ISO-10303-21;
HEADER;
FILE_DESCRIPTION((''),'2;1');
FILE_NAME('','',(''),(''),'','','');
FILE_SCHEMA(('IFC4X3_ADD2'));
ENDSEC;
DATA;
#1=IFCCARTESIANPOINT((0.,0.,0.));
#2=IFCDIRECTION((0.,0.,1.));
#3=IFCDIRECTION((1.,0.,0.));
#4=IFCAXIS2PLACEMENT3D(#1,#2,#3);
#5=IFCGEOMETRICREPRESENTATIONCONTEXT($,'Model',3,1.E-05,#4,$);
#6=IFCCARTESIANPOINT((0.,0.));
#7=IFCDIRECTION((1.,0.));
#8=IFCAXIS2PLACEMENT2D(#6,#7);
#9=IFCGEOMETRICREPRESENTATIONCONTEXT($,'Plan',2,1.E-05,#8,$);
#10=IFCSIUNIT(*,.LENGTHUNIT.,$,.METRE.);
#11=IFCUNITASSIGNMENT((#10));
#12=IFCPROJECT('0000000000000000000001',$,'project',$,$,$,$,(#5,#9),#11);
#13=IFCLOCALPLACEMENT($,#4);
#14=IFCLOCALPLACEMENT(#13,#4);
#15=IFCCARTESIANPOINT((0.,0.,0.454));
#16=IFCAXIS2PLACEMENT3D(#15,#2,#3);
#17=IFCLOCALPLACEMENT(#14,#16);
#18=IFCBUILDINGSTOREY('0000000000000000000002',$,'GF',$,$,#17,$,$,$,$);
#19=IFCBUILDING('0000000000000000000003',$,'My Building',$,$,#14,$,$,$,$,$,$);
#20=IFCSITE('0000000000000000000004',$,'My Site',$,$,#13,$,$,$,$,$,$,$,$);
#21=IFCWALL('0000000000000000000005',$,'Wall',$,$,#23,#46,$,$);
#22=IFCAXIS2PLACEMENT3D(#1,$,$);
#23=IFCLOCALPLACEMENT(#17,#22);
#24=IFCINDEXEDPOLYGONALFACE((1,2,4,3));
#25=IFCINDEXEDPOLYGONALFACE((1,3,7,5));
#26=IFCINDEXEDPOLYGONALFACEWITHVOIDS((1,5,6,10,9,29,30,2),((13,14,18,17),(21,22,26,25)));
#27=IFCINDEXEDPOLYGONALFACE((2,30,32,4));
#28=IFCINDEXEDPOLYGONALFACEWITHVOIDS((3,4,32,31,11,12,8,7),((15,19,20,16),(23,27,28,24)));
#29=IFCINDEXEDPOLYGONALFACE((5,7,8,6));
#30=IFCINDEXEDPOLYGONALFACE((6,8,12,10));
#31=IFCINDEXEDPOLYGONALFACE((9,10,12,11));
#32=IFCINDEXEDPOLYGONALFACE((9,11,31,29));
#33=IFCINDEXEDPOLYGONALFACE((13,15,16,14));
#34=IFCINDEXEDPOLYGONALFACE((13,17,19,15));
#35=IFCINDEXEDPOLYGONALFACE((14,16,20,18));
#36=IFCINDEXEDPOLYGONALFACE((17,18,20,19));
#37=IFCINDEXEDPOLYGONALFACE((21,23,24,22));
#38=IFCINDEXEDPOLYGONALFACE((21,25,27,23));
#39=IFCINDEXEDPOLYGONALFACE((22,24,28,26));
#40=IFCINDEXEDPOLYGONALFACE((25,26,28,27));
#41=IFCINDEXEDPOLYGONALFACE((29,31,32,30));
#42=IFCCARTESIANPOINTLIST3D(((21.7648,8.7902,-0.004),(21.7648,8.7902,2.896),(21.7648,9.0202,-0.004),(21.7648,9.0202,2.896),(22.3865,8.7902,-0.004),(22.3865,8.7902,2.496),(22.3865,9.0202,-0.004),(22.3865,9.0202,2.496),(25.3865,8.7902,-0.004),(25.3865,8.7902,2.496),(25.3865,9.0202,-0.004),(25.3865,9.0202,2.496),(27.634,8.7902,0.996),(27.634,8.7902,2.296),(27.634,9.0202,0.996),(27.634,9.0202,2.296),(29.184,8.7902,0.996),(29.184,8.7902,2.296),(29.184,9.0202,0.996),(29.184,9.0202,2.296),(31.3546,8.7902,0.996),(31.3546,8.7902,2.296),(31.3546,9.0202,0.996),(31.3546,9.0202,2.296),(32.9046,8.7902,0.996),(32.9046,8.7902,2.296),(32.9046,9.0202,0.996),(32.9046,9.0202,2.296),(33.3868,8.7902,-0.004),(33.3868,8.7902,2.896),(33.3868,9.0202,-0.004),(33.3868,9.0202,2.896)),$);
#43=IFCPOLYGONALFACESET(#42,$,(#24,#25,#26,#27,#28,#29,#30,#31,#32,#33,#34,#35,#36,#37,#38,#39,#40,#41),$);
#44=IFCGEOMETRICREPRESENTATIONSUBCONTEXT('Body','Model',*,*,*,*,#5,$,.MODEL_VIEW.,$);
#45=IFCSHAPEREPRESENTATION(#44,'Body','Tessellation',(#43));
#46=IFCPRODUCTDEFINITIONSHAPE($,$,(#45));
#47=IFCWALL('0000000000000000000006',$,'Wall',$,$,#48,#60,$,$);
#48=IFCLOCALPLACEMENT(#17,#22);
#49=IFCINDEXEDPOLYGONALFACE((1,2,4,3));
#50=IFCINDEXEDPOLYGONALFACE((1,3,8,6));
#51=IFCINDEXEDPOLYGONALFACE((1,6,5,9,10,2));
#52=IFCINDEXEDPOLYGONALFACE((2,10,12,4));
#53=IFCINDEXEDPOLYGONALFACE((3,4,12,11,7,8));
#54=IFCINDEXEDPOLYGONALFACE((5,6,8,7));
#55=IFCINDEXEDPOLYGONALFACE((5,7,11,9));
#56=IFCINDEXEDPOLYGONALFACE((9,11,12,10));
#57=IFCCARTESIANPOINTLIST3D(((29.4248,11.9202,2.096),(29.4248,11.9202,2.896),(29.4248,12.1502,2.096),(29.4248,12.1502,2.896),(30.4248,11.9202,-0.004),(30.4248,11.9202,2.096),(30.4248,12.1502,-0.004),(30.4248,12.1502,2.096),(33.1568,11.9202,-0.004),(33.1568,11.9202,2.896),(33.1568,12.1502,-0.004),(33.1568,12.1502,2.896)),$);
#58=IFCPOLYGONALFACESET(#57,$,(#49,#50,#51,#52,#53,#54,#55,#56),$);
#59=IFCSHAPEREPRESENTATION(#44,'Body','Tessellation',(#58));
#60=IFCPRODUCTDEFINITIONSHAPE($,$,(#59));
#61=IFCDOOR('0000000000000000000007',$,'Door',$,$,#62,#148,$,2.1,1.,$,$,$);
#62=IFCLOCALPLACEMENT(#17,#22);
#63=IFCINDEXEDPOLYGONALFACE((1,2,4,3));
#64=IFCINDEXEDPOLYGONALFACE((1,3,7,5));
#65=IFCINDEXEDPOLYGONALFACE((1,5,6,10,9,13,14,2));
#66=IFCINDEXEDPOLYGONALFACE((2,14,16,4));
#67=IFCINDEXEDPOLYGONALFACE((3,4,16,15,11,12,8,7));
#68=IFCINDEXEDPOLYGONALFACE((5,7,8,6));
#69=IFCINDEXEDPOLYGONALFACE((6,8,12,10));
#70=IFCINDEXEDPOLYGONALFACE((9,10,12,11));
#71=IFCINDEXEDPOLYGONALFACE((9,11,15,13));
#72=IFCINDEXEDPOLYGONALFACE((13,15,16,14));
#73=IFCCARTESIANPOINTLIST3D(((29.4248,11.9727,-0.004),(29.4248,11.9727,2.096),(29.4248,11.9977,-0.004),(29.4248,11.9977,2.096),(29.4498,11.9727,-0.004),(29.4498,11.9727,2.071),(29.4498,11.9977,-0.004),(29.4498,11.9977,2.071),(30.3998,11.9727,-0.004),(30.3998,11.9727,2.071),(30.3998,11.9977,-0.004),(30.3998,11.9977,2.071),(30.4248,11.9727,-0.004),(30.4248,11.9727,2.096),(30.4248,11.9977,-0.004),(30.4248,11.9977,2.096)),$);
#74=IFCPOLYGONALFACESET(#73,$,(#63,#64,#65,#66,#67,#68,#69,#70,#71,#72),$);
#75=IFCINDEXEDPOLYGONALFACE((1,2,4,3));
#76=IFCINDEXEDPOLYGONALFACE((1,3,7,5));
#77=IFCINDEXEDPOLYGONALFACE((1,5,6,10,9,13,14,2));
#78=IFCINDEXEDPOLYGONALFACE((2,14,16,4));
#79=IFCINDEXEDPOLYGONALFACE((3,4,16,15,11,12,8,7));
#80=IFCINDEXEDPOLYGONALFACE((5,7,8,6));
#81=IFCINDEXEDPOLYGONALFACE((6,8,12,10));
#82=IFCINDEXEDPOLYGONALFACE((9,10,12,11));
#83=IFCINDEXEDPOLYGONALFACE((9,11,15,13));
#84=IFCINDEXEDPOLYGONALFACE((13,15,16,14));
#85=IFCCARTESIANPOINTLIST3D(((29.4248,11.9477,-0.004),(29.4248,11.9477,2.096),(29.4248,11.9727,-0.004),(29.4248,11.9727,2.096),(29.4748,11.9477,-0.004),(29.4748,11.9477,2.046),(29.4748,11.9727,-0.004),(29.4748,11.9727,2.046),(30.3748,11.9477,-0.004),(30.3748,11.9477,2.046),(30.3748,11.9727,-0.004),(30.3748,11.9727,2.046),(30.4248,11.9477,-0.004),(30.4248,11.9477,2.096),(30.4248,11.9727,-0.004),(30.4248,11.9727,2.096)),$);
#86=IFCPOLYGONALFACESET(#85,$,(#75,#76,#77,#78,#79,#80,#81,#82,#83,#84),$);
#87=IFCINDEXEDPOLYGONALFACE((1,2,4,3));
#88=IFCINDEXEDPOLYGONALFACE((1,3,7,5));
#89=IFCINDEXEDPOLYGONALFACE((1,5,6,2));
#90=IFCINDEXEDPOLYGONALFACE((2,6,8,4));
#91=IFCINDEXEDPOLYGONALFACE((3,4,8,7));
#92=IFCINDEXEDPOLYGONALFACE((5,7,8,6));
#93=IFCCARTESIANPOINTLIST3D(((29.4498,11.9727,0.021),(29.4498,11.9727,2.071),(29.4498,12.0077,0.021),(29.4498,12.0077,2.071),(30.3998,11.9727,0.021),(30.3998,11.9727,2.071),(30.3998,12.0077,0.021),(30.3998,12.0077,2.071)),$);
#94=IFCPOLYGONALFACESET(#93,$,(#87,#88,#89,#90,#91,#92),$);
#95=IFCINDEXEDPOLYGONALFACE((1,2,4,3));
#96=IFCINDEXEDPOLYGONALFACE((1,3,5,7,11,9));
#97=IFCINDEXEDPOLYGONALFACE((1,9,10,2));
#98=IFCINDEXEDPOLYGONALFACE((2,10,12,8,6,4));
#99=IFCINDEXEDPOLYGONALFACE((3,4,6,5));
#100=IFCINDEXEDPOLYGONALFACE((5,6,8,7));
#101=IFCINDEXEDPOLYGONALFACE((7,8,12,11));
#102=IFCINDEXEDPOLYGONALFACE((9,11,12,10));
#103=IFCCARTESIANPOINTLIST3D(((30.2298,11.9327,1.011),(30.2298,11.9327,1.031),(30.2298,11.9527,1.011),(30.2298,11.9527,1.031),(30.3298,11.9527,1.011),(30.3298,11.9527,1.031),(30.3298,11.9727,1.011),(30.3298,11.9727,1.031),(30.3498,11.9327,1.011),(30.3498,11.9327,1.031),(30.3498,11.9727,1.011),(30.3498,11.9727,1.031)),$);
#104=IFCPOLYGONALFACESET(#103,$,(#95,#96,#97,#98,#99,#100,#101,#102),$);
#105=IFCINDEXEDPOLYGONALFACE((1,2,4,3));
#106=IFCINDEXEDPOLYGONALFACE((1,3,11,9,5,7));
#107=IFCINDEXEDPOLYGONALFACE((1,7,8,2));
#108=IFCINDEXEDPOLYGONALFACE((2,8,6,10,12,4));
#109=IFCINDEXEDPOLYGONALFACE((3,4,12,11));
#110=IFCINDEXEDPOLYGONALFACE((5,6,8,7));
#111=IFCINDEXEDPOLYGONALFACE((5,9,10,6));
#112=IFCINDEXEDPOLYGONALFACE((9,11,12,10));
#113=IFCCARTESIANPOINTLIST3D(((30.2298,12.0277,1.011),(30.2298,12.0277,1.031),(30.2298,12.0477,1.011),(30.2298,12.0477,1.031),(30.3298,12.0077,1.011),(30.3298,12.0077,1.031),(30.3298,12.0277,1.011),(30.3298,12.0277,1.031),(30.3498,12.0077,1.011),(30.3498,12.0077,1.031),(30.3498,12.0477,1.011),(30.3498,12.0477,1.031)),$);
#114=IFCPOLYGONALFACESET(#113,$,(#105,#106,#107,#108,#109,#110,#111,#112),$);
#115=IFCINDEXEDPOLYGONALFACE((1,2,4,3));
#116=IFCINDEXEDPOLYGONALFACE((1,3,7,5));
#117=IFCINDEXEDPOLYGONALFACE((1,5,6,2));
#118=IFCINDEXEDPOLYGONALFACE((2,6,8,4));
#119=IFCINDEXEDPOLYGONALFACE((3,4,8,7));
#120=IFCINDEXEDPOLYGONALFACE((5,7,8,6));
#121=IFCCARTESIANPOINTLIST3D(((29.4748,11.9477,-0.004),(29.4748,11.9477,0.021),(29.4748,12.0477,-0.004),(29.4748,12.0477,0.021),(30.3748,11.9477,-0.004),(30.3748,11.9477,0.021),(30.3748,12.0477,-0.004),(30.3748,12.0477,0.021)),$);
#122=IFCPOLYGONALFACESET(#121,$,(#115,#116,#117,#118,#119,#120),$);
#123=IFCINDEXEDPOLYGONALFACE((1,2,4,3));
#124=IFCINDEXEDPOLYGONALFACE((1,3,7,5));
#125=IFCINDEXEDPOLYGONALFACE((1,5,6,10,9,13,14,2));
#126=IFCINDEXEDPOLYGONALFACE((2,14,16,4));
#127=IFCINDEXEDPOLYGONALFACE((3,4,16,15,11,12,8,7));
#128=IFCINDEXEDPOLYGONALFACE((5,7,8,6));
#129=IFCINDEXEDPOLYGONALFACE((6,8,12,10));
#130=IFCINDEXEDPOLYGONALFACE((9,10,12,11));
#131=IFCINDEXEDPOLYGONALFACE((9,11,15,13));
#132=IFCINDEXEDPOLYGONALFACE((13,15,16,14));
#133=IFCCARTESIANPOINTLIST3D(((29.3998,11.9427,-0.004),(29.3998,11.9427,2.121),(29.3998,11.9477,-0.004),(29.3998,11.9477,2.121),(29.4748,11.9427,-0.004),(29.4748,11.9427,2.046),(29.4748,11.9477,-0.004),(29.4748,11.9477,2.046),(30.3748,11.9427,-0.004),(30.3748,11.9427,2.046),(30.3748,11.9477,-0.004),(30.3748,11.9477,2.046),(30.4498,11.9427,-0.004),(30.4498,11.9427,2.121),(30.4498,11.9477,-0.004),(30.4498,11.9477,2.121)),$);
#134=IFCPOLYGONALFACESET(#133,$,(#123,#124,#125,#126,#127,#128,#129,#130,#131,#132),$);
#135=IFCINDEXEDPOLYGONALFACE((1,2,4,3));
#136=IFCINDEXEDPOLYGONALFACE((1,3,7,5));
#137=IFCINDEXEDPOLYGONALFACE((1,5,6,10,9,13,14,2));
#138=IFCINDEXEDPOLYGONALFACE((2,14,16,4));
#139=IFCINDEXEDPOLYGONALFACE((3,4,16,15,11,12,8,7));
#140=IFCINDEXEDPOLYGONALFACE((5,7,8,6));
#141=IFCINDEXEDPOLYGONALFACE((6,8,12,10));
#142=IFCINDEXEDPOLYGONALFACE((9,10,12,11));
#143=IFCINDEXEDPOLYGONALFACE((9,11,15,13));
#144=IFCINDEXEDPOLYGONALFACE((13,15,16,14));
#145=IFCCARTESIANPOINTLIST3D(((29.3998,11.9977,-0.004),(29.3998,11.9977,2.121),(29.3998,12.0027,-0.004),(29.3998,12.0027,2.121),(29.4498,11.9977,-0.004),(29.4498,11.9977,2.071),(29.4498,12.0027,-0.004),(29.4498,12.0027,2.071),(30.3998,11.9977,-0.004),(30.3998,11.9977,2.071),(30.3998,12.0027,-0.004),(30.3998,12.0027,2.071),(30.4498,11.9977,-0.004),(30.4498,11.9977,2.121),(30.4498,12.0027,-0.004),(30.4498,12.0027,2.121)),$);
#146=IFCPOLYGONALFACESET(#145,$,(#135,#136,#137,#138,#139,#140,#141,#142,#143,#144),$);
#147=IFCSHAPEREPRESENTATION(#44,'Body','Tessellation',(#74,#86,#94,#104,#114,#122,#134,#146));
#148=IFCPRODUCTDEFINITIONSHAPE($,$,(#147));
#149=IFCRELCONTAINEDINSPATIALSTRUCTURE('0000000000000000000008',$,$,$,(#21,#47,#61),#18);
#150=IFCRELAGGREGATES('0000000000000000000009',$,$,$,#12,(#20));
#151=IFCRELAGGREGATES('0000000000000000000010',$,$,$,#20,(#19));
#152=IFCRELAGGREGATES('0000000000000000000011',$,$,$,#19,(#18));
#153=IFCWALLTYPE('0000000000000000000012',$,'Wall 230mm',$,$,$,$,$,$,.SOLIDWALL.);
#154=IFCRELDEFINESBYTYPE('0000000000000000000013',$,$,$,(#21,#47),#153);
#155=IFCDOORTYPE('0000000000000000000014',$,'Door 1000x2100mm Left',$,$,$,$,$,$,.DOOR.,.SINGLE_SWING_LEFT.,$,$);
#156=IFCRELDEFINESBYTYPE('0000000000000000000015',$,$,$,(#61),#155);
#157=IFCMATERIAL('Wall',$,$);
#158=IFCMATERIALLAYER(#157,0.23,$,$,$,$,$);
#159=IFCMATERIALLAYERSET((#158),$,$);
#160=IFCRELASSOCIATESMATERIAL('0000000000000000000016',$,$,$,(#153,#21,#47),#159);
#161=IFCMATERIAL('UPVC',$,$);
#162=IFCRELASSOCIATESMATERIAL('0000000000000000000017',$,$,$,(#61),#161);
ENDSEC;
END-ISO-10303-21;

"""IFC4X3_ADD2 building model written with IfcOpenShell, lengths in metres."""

from ifc_helpers import new_model, entity, si_unit, frame, origin_with_axes, origin_2d_with_axis, place, context, subcontext, project, spatial, line, indexed_curve, outline, extrude, shape, source, transform, mapped, material, layer, layer_set, layer_usage, type_object, type_shapes, element, fill, save


model = new_model("IFC4X3_ADD2")

# Units and contexts
model_context = context("Model", 3, precision=1e-05, world=origin_with_axes())
plan_context = context("Plan", 2, precision=1e-05, world=origin_2d_with_axis())
body_context_1 = subcontext(model_context, "Body", "Model", "MODEL_VIEW")
body_context_2 = subcontext(plan_context, "Body", "Plan", "PLAN_VIEW")
ifc_project = project(units=[si_unit("LENGTHUNIT", "METRE")], contexts=[model_context, plan_context])

# Site, building, storey
site_placement = place(None, origin_with_axes())
site = spatial("IfcSite", under=ifc_project, at=site_placement, Name="My Site")
building_placement = place(site_placement, origin_with_axes())
building = spatial("IfcBuilding", under=site, at=building_placement, Name="My Building")
storey_placement = place(building_placement, frame((0.0, 0.0, 0.454), z_axis=(0.0, 0.0, 1.0), x_axis=(1.0, 0.0, 0.0)))
storey = spatial("IfcBuildingStorey", under=building, at=storey_placement, Name="GF")

# Shared definitions
ifc_material_1 = material(Name="Wall")

# Wall, openings
ifc_layer_1 = layer(ifc_material_1, 0.23)
ifc_layer_set_1 = layer_set([ifc_layer_1])
ifc_layer_usage_1 = layer_usage(ifc_layer_set_1, "AXIS2", "POSITIVE", 0.0)
wall_type_1 = type_object("IfcWallType", Name="Wall 230mm", PredefinedType="SOLIDWALL", material=ifc_layer_set_1)
wall_1_placement = place(storey_placement, frame((33.3868, 9.0202, -0.004), z_axis=(0.0, 0.0, 1.0), x_axis=(-1.0, 0.0, 0.0)))
wall_1 = element("IfcWall", 1, at=wall_1_placement, inside=storey, type_object=wall_type_1, material=ifc_layer_usage_1, Name="Wall", context=body_context_1, shape_type="SweptSolid", body=[
    extrude(outline(indexed_curve([(0.0, 0.0), (0.0, 0.23), (11.622, 0.23), (11.622, 0.0), (0.0, 0.0)], self_intersect=False)), origin_with_axes(), (0.0, 0.0, 1.0), 2.9),
])
shared_shape_1 = source(origin_with_axes(), body_context_1, "Body", "SweptSolid", [
    extrude(outline(indexed_curve([(0.0, 0.0), (3.0, 0.0), (3.0, 2.5), (0.0, 2.5)], segments=[line(1, 2, 3, 4, 1)])), frame((0.0, -0.6, 0.0), z_axis=(0.0, -1.0, 0.0), x_axis=(1.0, 0.0, 0.0)), (0.0, 0.0, -1.0), 1.2),
])
opening_1_placement = place(wall_1_placement, frame((8.0003, 0.0, 0.0), z_axis=(0.0, 0.0, 1.0), x_axis=(1.0, 0.0, 0.0)))
element("IfcOpeningElement", 2, at=opening_1_placement, cuts=wall_1, PredefinedType="OPENING", context=body_context_1, shape_type="MappedRepresentation", body=[
    mapped(shared_shape_1, transform((0.0, 0.0, 0.0), x_axis=(1.0, 0.0, 0.0), y_axis=(0.0, 1.0, 0.0), z_axis=(0.0, 0.0, 1.0), scale=1.0)),
])
shared_shape_2 = source(origin_with_axes(), body_context_1, "Body", "SweptSolid", [
    extrude(outline(indexed_curve([(0.0, 0.0), (1.55, 0.0), (1.55, 1.3), (0.0, 1.3)], segments=[line(1, 2, 3, 4, 1)])), frame((-0.775, -0.6, 0.0), z_axis=(0.0, -1.0, 0.0), x_axis=(1.0, 0.0, 0.0)), (0.0, 0.0, -1.0), 1.2),
])
opening_2_placement = place(wall_1_placement, frame((1.2571, 0.0, 1.0), z_axis=(0.0, 0.0, 1.0), x_axis=(1.0, 0.0, 0.0)))
element("IfcOpeningElement", 3, at=opening_2_placement, cuts=wall_1, PredefinedType="OPENING", context=body_context_1, shape_type="MappedRepresentation", body=[
    mapped(shared_shape_2, transform((0.0, 0.0, 0.0), x_axis=(1.0, 0.0, 0.0), y_axis=(0.0, 1.0, 0.0), z_axis=(0.0, 0.0, 1.0), scale=1.0)),
])
opening_3_placement = place(wall_1_placement, frame((4.9778, 0.0, 1.0), z_axis=(0.0, 0.0, 1.0), x_axis=(1.0, 0.0, 0.0)))
element("IfcOpeningElement", 4, at=opening_3_placement, cuts=wall_1, PredefinedType="OPENING", context=body_context_1, shape_type="MappedRepresentation", body=[
    mapped(shared_shape_2, transform((0.0, 0.0, 0.0), x_axis=(1.0, 0.0, 0.0), y_axis=(0.0, 1.0, 0.0), z_axis=(0.0, 0.0, 1.0), scale=1.0)),
])

# Wall, opening, door
ifc_layer_usage_2 = layer_usage(ifc_layer_set_1, "AXIS2", "POSITIVE", 0.0)
wall_2_placement = place(storey_placement, frame((33.1568, 12.1502, -0.004), z_axis=(0.0, 0.0, 1.0), x_axis=(-1.0, 0.0, 0.0)))
wall_2 = element("IfcWall", 5, at=wall_2_placement, inside=storey, type_object=wall_type_1, material=ifc_layer_usage_2, Name="Wall", context=body_context_1, shape_type="SweptSolid", body=[
    extrude(outline(indexed_curve([(0.0, 0.0), (0.0, 0.23), (3.732, 0.23), (3.732, 0.0), (0.0, 0.0)], self_intersect=False)), origin_with_axes(), (0.0, 0.0, 1.0), 2.9),
])
shared_shape_3 = source(origin_with_axes(), body_context_1, "Body", "SweptSolid", [
    extrude(outline(indexed_curve([(0.0, 0.0), (1.0, 0.0), (1.0, 2.1), (0.0, 2.1)], segments=[line(1, 2, 3, 4, 1)])), frame((0.0, -0.6, 0.0), z_axis=(0.0, -1.0, 0.0), x_axis=(1.0, 0.0, 0.0)), (0.0, 0.0, -1.0), 1.2),
])
opening_4_placement = place(wall_2_placement, frame((3.732, 0.2024, 0.0), z_axis=(0.0, 0.0, 1.0), x_axis=(-1.0, 0.0, 0.0)))
opening_4 = element("IfcOpeningElement", 6, at=opening_4_placement, cuts=wall_2, PredefinedType="OPENING", context=body_context_1, shape_type="MappedRepresentation", body=[
    mapped(shared_shape_3, transform((0.0, 0.0, 0.0), x_axis=(1.0, 0.0, 0.0), y_axis=(0.0, 1.0, 0.0), z_axis=(0.0, 0.0, 1.0), scale=1.0)),
])
ifc_material_2 = material(Name="UPVC")
door_type = type_object("IfcDoorType", Name="Door 1000x2100mm Left", OperationType="SINGLE_SWING_LEFT", PredefinedType="DOOR")
shared_shape_4 = source(origin_with_axes(), body_context_1, "Body", "SweptSolid", [
    extrude(outline(indexed_curve([(0.0, 0.0), (0.0, 2.1), (1.0, 2.1), (1.0, 0.0), (0.975, 0.0), (0.975, 2.075), (0.025, 2.075), (0.025, 0.0)], segments=[line(1, 2, 3, 4, 5, 6, 7, 8, 1)])), frame((0.0, 0.025, 0.0), z_axis=(0.0, -1.0, 0.0), x_axis=(1.0, 0.0, 0.0)), (0.0, 0.0, -1.0), 0.025),
    extrude(outline(indexed_curve([(0.0, 0.0), (0.0, 2.1), (1.0, 2.1), (1.0, 0.0), (0.95, 0.0), (0.95, 2.05), (0.05, 2.05), (0.05, 0.0)], segments=[line(1, 2, 3, 4, 5, 6, 7, 8, 1)])), frame((0.0, 0.0, 0.0), z_axis=(0.0, -1.0, 0.0), x_axis=(1.0, 0.0, 0.0)), (0.0, 0.0, -1.0), 0.025),
    extrude(outline(indexed_curve([(0.0, 0.0), (0.95, 0.0), (0.95, 0.035), (0.0, 0.035)], segments=[line(1, 2, 3, 4, 1)])), frame((0.025, 0.025, 0.025), z_axis=(0.0, 0.0, 1.0), x_axis=(1.0, 0.0, 0.0)), (0.0, 0.0, 1.0), 2.05),
    extrude(outline(indexed_curve([(0.0, 0.0), (0.0, -0.04), (-0.12, -0.04), (-0.12, -0.02), (-0.02, -0.02), (-0.02, 0.0)], segments=[line(1, 2, 3, 4, 5, 6, 1)])), frame((0.925, 0.025, 1.015), z_axis=(0.0, 0.0, 1.0), x_axis=(1.0, 0.0, 0.0)), (0.0, 0.0, 1.0), 0.02),
    extrude(outline(indexed_curve([(0.0, 0.0), (0.0, 0.04), (-0.12, 0.04), (-0.12, 0.02), (-0.02, 0.02), (-0.02, 0.0)], segments=[line(1, 2, 3, 4, 5, 6, 1)])), frame((0.925, 0.06, 1.015), z_axis=(0.0, 0.0, 1.0), x_axis=(1.0, 0.0, 0.0)), (0.0, 0.0, 1.0), 0.02),
    extrude(outline(indexed_curve([(0.0, 0.0), (0.9, 0.0), (0.9, 0.1), (0.0, 0.1)], segments=[line(1, 2, 3, 4, 1)])), frame((0.05, 0.0, 0.0), z_axis=(0.0, 0.0, 1.0), x_axis=(1.0, 0.0, 0.0)), (0.0, 0.0, 1.0), 0.025),
    extrude(outline(indexed_curve([(0.0, 0.0), (0.0, 2.125), (1.05, 2.125), (1.05, 0.0), (0.975, 0.0), (0.975, 2.05), (0.075, 2.05), (0.075, 0.0)], segments=[line(1, 2, 3, 4, 5, 6, 7, 8, 1)])), frame((-0.025, -0.005, 0.0), z_axis=(0.0, -1.0, 0.0), x_axis=(1.0, 0.0, 0.0)), (0.0, 0.0, -1.0), 0.005),
    extrude(outline(indexed_curve([(0.0, 0.0), (0.0, 2.125), (1.05, 2.125), (1.05, 0.0), (1.0, 0.0), (1.0, 2.075), (0.05, 2.075), (0.05, 0.0)], segments=[line(1, 2, 3, 4, 5, 6, 7, 8, 1)])), frame((-0.025, 0.05, 0.0), z_axis=(0.0, -1.0, 0.0), x_axis=(1.0, 0.0, 0.0)), (0.0, 0.0, -1.0), 0.005),
])
shared_shape_5 = source(origin_with_axes(), body_context_2, "Body", "Curve2D", [
    entity("IfcIndexedPolyCurve", entity("IfcCartesianPointList2D", [[0.0, 0.0], [0.0, 0.05], [0.025, 0.05], [0.025, 0.025], [0.05, 0.025], [0.05, 0.0]]), [entity("IfcLineIndex", [1, 2, 3, 4, 5, 6, 1])]),
    entity("IfcIndexedPolyCurve", entity("IfcCartesianPointList2D", [[1.0, 0.0], [1.0, 0.05], [0.975, 0.05], [0.975, 0.025], [0.95, 0.025], [0.95, 0.0]]), [entity("IfcLineIndex", [1, 2, 3, 4, 5, 6, 1])]),
    entity("IfcTrimmedCurve", entity("IfcEllipse", entity("IfcAxis2Placement2D", entity("IfcCartesianPoint", [0.06, 0.05]), entity("IfcDirection", [1.0, 0.0])), 0.915, 0.95), [entity("IfcCartesianPoint", [0.975, 0.05])], [entity("IfcCartesianPoint", [0.06, 1.0])], True, "CARTESIAN"),
    entity("IfcIndexedPolyCurve", entity("IfcCartesianPointList2D", [[0.025, 0.05], [0.06, 0.05], [0.06, 1.0], [0.025, 1.0]]), [entity("IfcLineIndex", [1, 2, 3, 4, 1])]),
])
type_shapes(door_type, [shared_shape_4, shared_shape_5])
door_placement = place(opening_4_placement, frame((0.0, 0.0, 0.0), z_axis=(0.0, 0.0, 1.0), x_axis=(1.0, 0.0, 0.0)))
door = element("IfcDoor", 7, at=door_placement, inside=storey, type_object=door_type, material=ifc_material_2, Name="Door", OverallHeight=2.1, OverallWidth=1.0, shapes=[
    shape(body_context_1, "Body", "MappedRepresentation", [mapped(shared_shape_4, transform((0.0, 0.0, 0.0), x_axis=(1.0, 0.0, 0.0), y_axis=(0.0, 1.0, 0.0), z_axis=(0.0, 0.0, 1.0), scale=1.0))]),
    shape(body_context_2, "Body", "MappedRepresentation", [mapped(shared_shape_5, transform((0.0, 0.0, 0.0), x_axis=(1.0, 0.0, 0.0), y_axis=(0.0, 1.0, 0.0), z_axis=(0.0, 0.0, 1.0), scale=1.0))]),
])
fill(opening_4, door)

save(model, "model.ifc")
